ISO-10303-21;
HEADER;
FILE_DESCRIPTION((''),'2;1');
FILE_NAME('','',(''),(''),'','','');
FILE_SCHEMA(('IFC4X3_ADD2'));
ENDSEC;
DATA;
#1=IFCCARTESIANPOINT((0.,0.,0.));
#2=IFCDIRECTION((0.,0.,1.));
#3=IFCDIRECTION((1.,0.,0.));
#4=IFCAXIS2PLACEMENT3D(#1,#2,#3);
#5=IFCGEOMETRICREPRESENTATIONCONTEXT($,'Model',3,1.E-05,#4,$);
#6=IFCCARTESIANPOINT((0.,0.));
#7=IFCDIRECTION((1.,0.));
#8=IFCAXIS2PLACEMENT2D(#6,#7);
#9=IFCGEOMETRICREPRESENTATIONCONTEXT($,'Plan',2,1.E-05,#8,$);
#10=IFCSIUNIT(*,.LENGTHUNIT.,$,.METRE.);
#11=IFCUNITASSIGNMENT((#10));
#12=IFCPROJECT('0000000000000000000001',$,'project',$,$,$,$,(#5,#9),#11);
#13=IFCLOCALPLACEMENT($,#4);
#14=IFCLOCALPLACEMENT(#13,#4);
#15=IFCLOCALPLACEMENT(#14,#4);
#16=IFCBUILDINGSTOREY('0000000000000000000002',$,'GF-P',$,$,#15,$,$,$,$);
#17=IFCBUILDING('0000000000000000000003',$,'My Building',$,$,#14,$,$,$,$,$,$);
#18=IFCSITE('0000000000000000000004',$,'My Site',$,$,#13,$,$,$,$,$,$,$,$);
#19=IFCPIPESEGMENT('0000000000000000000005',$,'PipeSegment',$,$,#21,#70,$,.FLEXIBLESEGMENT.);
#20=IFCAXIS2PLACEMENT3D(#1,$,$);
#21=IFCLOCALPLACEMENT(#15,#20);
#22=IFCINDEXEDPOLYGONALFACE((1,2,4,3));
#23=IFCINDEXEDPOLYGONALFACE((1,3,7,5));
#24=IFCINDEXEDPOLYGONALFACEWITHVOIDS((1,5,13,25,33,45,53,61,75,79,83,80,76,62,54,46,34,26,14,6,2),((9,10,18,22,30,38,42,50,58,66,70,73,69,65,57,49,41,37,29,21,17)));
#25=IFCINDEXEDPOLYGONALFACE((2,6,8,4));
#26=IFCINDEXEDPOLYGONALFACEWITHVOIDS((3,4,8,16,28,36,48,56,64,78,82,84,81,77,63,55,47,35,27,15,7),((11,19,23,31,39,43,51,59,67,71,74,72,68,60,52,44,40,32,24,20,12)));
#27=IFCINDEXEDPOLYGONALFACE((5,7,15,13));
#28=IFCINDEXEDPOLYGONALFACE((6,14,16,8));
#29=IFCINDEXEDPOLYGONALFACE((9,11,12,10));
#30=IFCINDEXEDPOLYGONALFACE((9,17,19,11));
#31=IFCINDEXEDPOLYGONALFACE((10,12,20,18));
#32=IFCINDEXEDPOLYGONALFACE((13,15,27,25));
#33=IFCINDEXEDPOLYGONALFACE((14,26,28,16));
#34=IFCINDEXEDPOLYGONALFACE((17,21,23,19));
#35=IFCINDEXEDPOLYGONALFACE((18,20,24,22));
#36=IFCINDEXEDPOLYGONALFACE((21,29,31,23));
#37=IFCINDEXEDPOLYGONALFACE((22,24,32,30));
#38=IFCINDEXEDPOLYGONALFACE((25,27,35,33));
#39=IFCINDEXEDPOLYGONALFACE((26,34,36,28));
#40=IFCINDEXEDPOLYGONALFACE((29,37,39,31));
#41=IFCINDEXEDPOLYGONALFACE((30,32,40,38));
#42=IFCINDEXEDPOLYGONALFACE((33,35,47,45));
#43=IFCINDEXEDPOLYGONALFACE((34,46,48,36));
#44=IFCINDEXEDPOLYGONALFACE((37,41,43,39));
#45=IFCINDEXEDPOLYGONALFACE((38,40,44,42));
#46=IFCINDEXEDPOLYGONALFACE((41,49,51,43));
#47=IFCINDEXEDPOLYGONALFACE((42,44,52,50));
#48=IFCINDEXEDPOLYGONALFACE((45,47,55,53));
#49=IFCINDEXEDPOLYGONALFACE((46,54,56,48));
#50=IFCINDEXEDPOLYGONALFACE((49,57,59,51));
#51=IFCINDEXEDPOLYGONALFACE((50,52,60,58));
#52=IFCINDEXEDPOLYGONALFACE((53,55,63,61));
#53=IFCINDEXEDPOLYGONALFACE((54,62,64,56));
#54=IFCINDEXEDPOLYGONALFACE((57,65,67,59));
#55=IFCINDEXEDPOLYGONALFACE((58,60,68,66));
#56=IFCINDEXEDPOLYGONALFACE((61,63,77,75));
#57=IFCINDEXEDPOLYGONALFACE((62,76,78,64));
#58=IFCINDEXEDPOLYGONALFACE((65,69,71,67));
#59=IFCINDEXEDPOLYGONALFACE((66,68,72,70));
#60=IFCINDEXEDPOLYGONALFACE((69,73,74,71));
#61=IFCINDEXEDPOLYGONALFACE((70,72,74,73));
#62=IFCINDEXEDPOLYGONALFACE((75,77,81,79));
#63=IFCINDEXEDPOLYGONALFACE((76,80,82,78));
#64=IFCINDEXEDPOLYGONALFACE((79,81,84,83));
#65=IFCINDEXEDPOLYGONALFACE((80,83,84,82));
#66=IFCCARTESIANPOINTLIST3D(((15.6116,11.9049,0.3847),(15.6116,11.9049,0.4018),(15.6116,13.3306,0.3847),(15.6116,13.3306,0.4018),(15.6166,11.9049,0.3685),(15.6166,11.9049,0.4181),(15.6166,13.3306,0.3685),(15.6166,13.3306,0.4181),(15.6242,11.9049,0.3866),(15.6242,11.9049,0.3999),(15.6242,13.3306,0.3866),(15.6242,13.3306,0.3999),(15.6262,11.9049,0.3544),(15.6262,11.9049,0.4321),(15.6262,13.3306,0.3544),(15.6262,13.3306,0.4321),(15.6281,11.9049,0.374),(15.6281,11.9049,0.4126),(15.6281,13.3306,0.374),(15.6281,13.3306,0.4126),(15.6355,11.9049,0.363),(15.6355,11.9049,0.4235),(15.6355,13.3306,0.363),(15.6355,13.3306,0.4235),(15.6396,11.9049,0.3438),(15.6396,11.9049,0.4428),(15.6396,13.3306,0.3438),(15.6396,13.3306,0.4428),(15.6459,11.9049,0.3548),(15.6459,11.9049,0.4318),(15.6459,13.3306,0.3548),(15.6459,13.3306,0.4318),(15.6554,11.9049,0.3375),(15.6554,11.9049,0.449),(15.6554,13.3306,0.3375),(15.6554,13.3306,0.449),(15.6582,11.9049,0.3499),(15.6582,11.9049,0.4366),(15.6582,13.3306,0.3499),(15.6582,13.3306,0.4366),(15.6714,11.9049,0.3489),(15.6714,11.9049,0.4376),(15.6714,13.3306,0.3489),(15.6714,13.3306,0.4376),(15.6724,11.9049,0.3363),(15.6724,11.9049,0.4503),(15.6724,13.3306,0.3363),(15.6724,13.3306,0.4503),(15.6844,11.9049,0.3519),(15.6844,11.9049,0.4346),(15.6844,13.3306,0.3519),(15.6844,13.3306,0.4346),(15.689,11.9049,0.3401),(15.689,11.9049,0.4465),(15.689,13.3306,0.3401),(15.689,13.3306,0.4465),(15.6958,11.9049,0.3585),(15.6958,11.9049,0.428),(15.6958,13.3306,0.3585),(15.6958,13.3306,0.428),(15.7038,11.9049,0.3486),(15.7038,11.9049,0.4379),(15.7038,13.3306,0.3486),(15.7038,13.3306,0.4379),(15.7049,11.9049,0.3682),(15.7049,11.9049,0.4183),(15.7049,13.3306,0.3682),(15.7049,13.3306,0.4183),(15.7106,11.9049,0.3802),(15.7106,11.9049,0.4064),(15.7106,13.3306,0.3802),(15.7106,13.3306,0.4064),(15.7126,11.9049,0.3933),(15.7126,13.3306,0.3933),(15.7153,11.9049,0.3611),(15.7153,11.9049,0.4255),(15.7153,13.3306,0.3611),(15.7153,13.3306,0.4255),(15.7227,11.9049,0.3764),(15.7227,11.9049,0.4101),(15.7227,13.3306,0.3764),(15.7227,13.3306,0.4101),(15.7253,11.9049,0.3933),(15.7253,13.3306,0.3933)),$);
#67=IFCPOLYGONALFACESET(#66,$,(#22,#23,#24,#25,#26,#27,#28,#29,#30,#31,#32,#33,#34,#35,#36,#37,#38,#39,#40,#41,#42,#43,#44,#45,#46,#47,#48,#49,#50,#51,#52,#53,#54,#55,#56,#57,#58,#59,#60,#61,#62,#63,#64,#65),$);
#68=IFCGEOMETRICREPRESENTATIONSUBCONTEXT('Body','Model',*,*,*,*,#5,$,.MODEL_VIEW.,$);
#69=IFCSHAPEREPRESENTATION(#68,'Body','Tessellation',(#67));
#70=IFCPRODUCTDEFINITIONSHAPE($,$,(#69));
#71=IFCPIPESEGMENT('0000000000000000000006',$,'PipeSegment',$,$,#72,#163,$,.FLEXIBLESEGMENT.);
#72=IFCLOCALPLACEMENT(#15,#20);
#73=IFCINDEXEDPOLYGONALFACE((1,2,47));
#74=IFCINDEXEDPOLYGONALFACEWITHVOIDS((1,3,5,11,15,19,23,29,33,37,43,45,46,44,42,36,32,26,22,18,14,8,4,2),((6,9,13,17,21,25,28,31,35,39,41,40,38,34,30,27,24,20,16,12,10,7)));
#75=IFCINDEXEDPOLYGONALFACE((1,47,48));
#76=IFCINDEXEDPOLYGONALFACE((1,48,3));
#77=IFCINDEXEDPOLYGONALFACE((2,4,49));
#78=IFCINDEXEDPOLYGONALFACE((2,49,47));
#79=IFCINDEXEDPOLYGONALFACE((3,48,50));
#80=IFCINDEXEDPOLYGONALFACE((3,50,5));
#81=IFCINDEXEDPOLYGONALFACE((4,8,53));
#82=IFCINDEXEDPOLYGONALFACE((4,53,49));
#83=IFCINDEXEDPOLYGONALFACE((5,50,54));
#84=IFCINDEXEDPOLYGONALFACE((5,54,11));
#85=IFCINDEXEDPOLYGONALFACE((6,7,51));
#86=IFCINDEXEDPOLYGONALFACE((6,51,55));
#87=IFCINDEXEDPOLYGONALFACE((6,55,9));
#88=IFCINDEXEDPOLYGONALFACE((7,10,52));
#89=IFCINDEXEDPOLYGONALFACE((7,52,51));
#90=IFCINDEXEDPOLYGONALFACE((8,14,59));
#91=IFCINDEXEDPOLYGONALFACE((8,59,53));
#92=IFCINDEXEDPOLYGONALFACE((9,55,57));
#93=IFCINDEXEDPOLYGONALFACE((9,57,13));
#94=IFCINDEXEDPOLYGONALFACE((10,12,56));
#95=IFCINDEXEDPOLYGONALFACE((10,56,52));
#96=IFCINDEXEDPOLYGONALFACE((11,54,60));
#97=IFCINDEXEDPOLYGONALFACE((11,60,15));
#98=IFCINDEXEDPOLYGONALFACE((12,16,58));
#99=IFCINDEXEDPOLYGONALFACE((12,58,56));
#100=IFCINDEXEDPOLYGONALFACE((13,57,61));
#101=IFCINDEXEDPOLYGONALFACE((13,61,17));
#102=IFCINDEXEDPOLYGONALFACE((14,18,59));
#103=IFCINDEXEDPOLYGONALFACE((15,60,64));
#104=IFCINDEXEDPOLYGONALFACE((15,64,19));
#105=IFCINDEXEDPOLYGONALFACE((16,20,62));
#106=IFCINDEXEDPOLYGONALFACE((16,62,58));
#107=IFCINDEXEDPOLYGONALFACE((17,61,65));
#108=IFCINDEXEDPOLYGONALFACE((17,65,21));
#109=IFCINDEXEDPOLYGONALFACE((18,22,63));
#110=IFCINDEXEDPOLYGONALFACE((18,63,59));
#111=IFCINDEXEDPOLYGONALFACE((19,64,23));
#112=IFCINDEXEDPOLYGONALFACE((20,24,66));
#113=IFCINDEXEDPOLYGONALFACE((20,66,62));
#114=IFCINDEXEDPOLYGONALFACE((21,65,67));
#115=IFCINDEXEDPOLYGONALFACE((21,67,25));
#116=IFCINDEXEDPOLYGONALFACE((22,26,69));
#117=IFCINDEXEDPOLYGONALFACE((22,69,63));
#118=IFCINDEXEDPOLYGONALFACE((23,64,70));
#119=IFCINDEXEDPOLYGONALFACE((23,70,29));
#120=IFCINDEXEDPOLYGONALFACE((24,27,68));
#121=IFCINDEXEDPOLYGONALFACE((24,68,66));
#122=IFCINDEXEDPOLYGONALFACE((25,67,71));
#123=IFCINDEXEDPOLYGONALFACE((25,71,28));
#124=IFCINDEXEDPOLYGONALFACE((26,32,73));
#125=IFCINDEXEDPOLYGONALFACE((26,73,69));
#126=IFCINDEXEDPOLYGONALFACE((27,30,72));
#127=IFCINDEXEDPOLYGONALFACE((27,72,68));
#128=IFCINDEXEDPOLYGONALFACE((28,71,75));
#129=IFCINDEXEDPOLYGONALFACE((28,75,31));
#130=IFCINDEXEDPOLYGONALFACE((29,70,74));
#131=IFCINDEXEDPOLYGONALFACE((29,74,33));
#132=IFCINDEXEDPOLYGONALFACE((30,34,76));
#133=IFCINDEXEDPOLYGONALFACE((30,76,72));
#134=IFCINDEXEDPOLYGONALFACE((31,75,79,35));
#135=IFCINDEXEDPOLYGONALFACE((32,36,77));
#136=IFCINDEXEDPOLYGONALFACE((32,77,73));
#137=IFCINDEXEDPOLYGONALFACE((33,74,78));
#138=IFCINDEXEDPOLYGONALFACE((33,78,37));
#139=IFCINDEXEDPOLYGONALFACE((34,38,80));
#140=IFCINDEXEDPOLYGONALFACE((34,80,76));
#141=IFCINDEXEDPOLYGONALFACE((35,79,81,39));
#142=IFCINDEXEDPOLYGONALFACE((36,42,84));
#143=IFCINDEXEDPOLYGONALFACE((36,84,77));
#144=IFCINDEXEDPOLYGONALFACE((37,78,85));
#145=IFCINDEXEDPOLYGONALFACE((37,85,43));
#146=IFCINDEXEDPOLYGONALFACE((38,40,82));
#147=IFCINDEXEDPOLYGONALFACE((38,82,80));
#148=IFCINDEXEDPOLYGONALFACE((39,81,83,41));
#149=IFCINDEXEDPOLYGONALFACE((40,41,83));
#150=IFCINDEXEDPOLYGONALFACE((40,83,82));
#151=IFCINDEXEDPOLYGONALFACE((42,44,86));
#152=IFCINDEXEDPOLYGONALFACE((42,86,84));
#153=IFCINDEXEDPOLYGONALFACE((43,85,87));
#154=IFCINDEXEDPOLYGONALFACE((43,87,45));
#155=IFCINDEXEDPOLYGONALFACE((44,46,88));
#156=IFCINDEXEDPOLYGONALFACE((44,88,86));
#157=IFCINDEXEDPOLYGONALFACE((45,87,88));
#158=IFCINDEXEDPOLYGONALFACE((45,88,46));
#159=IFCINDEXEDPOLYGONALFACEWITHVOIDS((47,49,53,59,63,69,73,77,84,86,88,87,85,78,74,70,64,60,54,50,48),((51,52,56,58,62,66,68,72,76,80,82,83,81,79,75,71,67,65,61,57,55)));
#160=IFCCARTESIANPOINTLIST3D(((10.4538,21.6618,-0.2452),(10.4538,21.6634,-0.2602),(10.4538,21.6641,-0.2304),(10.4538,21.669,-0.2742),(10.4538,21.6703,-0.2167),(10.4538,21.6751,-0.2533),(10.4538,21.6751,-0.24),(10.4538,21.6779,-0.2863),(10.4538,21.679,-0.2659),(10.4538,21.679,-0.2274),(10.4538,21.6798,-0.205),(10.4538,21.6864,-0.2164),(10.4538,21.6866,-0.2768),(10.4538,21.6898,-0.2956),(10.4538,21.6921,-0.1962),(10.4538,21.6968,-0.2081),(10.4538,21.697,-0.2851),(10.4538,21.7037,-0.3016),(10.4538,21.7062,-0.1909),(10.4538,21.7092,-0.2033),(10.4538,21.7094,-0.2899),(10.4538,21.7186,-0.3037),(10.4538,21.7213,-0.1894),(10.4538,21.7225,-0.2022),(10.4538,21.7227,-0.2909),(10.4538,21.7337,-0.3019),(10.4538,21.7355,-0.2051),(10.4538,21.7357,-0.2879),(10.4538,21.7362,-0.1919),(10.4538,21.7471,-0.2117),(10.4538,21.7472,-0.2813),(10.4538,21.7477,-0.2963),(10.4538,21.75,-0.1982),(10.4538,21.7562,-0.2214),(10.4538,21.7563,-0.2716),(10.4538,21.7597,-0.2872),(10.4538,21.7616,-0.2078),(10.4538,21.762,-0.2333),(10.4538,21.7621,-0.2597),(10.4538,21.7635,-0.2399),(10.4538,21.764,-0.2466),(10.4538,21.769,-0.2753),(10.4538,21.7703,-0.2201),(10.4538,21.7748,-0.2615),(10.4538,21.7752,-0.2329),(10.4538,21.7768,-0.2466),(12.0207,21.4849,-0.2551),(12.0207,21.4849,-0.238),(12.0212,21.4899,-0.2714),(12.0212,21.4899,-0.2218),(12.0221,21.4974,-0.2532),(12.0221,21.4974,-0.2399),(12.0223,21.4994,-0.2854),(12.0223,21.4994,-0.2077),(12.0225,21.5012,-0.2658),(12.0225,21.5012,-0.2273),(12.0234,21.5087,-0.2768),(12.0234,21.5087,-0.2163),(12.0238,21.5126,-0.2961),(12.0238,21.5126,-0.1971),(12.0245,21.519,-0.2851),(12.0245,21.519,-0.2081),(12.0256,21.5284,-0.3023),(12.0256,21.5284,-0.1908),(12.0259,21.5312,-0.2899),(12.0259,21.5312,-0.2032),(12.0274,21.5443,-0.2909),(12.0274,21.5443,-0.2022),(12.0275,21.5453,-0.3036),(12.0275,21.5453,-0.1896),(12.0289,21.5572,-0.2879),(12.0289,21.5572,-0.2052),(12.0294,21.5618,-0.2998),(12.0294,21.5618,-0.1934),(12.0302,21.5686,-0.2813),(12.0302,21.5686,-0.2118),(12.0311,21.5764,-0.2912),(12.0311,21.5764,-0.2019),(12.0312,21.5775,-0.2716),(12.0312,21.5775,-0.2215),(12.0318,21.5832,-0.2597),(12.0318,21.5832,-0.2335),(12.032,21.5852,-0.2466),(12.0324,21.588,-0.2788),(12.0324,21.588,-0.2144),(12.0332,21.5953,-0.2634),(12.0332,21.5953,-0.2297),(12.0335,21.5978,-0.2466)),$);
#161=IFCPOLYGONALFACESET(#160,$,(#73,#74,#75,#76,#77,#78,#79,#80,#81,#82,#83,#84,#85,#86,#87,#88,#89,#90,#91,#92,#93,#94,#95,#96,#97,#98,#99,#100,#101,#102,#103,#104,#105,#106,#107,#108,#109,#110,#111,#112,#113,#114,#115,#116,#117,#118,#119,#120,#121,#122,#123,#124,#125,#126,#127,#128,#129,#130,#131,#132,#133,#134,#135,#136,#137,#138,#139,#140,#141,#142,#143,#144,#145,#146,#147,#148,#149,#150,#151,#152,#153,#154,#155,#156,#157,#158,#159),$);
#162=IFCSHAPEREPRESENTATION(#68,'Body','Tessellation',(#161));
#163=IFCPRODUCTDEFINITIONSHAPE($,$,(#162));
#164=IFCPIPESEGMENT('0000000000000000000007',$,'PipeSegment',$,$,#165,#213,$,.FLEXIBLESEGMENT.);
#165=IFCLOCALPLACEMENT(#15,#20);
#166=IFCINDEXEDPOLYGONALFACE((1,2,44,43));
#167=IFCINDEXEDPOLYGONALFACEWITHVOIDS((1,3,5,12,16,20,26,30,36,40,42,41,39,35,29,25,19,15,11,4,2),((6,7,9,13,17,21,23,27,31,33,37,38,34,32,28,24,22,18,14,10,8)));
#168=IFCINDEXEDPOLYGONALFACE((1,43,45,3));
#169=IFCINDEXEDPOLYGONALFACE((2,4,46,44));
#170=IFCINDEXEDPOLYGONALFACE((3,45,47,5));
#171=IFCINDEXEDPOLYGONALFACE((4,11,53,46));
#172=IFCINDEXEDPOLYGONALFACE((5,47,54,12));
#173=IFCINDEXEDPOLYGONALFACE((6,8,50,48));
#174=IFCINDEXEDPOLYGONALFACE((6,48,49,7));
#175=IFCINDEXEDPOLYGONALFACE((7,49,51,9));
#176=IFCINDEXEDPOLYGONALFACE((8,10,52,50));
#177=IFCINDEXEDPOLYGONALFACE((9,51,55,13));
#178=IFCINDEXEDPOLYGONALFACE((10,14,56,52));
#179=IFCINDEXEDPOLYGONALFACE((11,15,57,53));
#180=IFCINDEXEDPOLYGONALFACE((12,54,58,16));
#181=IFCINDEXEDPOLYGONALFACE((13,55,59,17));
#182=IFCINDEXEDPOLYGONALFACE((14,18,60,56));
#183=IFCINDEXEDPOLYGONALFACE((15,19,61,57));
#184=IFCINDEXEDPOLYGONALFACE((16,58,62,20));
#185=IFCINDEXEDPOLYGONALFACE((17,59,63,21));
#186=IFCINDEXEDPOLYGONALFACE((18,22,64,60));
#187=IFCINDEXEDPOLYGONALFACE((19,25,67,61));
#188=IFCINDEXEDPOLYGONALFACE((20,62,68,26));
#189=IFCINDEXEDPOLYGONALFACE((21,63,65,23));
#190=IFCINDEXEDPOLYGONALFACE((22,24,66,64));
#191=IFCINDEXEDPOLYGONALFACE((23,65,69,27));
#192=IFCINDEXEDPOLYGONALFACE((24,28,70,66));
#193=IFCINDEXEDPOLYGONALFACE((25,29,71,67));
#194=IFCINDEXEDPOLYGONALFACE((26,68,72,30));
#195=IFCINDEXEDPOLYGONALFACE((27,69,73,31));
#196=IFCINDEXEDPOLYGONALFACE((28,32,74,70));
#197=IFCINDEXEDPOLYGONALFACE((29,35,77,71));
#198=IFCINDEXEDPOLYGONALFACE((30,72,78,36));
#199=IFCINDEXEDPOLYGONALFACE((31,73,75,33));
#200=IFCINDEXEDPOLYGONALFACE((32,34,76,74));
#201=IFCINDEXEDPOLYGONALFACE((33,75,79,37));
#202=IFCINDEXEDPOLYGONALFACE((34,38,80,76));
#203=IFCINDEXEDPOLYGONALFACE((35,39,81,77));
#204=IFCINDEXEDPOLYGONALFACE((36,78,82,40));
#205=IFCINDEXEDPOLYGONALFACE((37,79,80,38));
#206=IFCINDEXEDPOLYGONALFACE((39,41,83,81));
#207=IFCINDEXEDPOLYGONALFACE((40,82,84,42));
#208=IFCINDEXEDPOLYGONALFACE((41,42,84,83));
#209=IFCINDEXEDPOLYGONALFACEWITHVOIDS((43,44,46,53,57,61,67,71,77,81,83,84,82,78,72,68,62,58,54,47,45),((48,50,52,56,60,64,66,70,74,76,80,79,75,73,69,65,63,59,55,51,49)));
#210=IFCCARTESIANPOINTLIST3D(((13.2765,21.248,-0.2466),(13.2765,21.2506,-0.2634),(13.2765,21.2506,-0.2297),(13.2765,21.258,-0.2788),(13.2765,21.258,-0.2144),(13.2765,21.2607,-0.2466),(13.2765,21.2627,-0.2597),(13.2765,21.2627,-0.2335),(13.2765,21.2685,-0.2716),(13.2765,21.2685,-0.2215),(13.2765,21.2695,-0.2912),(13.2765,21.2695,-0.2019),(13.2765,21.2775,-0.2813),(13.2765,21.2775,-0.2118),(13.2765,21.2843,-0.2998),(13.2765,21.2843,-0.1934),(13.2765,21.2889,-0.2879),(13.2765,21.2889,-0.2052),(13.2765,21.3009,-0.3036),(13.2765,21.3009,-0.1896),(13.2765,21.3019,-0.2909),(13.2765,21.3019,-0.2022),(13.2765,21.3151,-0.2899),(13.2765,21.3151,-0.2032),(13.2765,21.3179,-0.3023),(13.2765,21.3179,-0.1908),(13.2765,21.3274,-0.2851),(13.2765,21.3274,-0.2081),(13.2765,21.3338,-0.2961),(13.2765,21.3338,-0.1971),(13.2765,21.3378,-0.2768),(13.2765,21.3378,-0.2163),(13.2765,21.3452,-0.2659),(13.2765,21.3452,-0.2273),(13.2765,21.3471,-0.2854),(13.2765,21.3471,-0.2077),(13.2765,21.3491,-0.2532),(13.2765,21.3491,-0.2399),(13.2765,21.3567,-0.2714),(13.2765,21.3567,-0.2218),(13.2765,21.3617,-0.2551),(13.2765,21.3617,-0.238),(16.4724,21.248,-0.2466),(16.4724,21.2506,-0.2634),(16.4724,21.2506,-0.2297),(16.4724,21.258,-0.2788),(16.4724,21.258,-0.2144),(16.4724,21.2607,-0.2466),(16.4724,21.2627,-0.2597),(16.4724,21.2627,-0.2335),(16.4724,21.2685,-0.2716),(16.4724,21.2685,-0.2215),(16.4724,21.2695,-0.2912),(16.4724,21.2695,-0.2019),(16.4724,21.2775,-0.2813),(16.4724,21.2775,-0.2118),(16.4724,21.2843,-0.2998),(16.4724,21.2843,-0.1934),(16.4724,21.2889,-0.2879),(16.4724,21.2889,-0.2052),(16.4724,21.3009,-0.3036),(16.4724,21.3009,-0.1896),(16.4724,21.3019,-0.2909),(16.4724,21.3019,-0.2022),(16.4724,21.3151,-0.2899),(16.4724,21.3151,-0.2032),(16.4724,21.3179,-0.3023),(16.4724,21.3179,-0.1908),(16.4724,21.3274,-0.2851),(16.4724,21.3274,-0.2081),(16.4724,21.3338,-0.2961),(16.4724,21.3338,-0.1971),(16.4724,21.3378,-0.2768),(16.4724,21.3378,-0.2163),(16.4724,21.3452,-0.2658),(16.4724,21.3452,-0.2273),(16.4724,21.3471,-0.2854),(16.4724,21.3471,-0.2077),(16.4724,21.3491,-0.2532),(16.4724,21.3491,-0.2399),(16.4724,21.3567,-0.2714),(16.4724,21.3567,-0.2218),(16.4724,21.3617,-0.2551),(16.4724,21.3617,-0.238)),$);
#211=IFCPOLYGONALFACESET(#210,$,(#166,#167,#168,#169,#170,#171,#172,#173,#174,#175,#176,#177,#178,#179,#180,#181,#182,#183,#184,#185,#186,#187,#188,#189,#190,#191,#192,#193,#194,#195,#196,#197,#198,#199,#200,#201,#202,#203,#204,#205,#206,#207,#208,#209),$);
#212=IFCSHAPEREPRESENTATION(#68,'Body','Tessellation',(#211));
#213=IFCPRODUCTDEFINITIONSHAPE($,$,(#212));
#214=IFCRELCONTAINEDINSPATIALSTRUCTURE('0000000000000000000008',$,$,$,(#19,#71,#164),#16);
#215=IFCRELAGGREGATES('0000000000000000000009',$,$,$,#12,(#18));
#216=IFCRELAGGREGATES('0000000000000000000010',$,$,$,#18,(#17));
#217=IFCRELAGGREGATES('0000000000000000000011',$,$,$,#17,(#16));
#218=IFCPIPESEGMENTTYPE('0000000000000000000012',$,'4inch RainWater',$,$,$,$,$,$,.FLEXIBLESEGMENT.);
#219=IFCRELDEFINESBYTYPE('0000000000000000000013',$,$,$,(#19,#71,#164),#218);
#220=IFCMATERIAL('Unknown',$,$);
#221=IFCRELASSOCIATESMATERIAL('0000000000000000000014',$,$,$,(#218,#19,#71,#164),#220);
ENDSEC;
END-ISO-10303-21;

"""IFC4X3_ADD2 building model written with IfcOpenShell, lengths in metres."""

from ifc_helpers import new_model, si_unit, frame, origin_with_axes, origin_2d_with_axis, place, context, subcontext, project, spatial, hollow_circle, extrude, clip, halfspace, material, material_profile, profile_set, profile_usage, type_object, element, save


model = new_model("IFC4X3_ADD2")

# Units and contexts
model_context = context("Model", 3, precision=1e-05, world=origin_with_axes())
plan_context = context("Plan", 2, precision=1e-05, world=origin_2d_with_axis())
body_context = subcontext(model_context, "Body", "Model", "MODEL_VIEW")
ifc_project = project(units=[si_unit("LENGTHUNIT", "METRE")], contexts=[model_context, plan_context])

# Site, building, storey
site_placement = place(None, origin_with_axes())
site = spatial("IfcSite", under=ifc_project, at=site_placement, Name="My Site")
building_placement = place(site_placement, origin_with_axes())
building = spatial("IfcBuilding", under=site, at=building_placement, Name="My Building")
storey_placement = place(building_placement, origin_with_axes())
storey = spatial("IfcBuildingStorey", under=building, at=storey_placement, Name="GF-P")

# Shared definitions
ifc_material_1 = material(Name="Unknown")

# Pipe segments
ifc_material_profile_1 = material_profile(ifc_material_1, hollow_circle(Radius=0.0571, WallThickness=0.0127))
ifc_profile_set_1 = profile_set([ifc_material_profile_1], Name="rainwater")
pipe_segment_type_1 = type_object("IfcPipeSegmentType", Name="4inch RainWater", PredefinedType="FLEXIBLESEGMENT", material=ifc_profile_set_1)
ifc_profile_usage_1 = profile_usage(ifc_profile_set_1)
pipe_segment_1_placement = place(storey_placement, frame((15.6681, 13.3306, 0.3933), z_axis=(0.0, -1.0, 0.0), x_axis=(1.0, 0.0, 0.0)))
element("IfcPipeSegment", 1, at=pipe_segment_1_placement, inside=storey, type_object=pipe_segment_type_1, material=ifc_profile_usage_1, Name="PipeSegment", PredefinedType="FLEXIBLESEGMENT", context=body_context, shape_type="SweptSolid", body=[
    extrude(hollow_circle(Radius=0.0571, WallThickness=0.0127), origin_with_axes(), (0.0, 0.0, 1.0), 1.4257),
])
ifc_profile_usage_2 = profile_usage(ifc_profile_set_1)
pipe_segment_2_placement = place(storey_placement, frame((10.3402, 21.7322, -0.2466), z_axis=(0.993641, -0.112595, 0.0), x_axis=(0.112595, 0.993641, 0.0)))
element("IfcPipeSegment", 2, at=pipe_segment_2_placement, inside=storey, type_object=pipe_segment_type_1, material=ifc_profile_usage_2, Name="PipeSegment", PredefinedType="FLEXIBLESEGMENT", context=body_context, shape_type="Clipping", body=[
    clip(extrude(hollow_circle(Radius=0.0571, WallThickness=0.0127), origin_with_axes(), (0.0, 0.0, 1.0), 1.6976), halfspace(frame((-0.006, 0.0567, 0.115), z_axis=(-0.112595, 0.0, -0.993641), x_axis=(0.0, 1.0, 0.0)), False)),
])
ifc_profile_usage_3 = profile_usage(ifc_profile_set_1)
pipe_segment_3_placement = place(storey_placement, frame((16.4724, 21.3052, -0.2466), z_axis=(-1.0, 0.0, 0.0), x_axis=(0.0, -1.0, 0.0)))
element("IfcPipeSegment", 3, at=pipe_segment_3_placement, inside=storey, type_object=pipe_segment_type_1, material=ifc_profile_usage_3, Name="PipeSegment", PredefinedType="FLEXIBLESEGMENT", context=body_context, shape_type="SweptSolid", body=[
    extrude(hollow_circle(Radius=0.0571, WallThickness=0.0127), origin_with_axes(), (0.0, 0.0, 1.0), 3.1958),
])

save(model, "model.ifc")
